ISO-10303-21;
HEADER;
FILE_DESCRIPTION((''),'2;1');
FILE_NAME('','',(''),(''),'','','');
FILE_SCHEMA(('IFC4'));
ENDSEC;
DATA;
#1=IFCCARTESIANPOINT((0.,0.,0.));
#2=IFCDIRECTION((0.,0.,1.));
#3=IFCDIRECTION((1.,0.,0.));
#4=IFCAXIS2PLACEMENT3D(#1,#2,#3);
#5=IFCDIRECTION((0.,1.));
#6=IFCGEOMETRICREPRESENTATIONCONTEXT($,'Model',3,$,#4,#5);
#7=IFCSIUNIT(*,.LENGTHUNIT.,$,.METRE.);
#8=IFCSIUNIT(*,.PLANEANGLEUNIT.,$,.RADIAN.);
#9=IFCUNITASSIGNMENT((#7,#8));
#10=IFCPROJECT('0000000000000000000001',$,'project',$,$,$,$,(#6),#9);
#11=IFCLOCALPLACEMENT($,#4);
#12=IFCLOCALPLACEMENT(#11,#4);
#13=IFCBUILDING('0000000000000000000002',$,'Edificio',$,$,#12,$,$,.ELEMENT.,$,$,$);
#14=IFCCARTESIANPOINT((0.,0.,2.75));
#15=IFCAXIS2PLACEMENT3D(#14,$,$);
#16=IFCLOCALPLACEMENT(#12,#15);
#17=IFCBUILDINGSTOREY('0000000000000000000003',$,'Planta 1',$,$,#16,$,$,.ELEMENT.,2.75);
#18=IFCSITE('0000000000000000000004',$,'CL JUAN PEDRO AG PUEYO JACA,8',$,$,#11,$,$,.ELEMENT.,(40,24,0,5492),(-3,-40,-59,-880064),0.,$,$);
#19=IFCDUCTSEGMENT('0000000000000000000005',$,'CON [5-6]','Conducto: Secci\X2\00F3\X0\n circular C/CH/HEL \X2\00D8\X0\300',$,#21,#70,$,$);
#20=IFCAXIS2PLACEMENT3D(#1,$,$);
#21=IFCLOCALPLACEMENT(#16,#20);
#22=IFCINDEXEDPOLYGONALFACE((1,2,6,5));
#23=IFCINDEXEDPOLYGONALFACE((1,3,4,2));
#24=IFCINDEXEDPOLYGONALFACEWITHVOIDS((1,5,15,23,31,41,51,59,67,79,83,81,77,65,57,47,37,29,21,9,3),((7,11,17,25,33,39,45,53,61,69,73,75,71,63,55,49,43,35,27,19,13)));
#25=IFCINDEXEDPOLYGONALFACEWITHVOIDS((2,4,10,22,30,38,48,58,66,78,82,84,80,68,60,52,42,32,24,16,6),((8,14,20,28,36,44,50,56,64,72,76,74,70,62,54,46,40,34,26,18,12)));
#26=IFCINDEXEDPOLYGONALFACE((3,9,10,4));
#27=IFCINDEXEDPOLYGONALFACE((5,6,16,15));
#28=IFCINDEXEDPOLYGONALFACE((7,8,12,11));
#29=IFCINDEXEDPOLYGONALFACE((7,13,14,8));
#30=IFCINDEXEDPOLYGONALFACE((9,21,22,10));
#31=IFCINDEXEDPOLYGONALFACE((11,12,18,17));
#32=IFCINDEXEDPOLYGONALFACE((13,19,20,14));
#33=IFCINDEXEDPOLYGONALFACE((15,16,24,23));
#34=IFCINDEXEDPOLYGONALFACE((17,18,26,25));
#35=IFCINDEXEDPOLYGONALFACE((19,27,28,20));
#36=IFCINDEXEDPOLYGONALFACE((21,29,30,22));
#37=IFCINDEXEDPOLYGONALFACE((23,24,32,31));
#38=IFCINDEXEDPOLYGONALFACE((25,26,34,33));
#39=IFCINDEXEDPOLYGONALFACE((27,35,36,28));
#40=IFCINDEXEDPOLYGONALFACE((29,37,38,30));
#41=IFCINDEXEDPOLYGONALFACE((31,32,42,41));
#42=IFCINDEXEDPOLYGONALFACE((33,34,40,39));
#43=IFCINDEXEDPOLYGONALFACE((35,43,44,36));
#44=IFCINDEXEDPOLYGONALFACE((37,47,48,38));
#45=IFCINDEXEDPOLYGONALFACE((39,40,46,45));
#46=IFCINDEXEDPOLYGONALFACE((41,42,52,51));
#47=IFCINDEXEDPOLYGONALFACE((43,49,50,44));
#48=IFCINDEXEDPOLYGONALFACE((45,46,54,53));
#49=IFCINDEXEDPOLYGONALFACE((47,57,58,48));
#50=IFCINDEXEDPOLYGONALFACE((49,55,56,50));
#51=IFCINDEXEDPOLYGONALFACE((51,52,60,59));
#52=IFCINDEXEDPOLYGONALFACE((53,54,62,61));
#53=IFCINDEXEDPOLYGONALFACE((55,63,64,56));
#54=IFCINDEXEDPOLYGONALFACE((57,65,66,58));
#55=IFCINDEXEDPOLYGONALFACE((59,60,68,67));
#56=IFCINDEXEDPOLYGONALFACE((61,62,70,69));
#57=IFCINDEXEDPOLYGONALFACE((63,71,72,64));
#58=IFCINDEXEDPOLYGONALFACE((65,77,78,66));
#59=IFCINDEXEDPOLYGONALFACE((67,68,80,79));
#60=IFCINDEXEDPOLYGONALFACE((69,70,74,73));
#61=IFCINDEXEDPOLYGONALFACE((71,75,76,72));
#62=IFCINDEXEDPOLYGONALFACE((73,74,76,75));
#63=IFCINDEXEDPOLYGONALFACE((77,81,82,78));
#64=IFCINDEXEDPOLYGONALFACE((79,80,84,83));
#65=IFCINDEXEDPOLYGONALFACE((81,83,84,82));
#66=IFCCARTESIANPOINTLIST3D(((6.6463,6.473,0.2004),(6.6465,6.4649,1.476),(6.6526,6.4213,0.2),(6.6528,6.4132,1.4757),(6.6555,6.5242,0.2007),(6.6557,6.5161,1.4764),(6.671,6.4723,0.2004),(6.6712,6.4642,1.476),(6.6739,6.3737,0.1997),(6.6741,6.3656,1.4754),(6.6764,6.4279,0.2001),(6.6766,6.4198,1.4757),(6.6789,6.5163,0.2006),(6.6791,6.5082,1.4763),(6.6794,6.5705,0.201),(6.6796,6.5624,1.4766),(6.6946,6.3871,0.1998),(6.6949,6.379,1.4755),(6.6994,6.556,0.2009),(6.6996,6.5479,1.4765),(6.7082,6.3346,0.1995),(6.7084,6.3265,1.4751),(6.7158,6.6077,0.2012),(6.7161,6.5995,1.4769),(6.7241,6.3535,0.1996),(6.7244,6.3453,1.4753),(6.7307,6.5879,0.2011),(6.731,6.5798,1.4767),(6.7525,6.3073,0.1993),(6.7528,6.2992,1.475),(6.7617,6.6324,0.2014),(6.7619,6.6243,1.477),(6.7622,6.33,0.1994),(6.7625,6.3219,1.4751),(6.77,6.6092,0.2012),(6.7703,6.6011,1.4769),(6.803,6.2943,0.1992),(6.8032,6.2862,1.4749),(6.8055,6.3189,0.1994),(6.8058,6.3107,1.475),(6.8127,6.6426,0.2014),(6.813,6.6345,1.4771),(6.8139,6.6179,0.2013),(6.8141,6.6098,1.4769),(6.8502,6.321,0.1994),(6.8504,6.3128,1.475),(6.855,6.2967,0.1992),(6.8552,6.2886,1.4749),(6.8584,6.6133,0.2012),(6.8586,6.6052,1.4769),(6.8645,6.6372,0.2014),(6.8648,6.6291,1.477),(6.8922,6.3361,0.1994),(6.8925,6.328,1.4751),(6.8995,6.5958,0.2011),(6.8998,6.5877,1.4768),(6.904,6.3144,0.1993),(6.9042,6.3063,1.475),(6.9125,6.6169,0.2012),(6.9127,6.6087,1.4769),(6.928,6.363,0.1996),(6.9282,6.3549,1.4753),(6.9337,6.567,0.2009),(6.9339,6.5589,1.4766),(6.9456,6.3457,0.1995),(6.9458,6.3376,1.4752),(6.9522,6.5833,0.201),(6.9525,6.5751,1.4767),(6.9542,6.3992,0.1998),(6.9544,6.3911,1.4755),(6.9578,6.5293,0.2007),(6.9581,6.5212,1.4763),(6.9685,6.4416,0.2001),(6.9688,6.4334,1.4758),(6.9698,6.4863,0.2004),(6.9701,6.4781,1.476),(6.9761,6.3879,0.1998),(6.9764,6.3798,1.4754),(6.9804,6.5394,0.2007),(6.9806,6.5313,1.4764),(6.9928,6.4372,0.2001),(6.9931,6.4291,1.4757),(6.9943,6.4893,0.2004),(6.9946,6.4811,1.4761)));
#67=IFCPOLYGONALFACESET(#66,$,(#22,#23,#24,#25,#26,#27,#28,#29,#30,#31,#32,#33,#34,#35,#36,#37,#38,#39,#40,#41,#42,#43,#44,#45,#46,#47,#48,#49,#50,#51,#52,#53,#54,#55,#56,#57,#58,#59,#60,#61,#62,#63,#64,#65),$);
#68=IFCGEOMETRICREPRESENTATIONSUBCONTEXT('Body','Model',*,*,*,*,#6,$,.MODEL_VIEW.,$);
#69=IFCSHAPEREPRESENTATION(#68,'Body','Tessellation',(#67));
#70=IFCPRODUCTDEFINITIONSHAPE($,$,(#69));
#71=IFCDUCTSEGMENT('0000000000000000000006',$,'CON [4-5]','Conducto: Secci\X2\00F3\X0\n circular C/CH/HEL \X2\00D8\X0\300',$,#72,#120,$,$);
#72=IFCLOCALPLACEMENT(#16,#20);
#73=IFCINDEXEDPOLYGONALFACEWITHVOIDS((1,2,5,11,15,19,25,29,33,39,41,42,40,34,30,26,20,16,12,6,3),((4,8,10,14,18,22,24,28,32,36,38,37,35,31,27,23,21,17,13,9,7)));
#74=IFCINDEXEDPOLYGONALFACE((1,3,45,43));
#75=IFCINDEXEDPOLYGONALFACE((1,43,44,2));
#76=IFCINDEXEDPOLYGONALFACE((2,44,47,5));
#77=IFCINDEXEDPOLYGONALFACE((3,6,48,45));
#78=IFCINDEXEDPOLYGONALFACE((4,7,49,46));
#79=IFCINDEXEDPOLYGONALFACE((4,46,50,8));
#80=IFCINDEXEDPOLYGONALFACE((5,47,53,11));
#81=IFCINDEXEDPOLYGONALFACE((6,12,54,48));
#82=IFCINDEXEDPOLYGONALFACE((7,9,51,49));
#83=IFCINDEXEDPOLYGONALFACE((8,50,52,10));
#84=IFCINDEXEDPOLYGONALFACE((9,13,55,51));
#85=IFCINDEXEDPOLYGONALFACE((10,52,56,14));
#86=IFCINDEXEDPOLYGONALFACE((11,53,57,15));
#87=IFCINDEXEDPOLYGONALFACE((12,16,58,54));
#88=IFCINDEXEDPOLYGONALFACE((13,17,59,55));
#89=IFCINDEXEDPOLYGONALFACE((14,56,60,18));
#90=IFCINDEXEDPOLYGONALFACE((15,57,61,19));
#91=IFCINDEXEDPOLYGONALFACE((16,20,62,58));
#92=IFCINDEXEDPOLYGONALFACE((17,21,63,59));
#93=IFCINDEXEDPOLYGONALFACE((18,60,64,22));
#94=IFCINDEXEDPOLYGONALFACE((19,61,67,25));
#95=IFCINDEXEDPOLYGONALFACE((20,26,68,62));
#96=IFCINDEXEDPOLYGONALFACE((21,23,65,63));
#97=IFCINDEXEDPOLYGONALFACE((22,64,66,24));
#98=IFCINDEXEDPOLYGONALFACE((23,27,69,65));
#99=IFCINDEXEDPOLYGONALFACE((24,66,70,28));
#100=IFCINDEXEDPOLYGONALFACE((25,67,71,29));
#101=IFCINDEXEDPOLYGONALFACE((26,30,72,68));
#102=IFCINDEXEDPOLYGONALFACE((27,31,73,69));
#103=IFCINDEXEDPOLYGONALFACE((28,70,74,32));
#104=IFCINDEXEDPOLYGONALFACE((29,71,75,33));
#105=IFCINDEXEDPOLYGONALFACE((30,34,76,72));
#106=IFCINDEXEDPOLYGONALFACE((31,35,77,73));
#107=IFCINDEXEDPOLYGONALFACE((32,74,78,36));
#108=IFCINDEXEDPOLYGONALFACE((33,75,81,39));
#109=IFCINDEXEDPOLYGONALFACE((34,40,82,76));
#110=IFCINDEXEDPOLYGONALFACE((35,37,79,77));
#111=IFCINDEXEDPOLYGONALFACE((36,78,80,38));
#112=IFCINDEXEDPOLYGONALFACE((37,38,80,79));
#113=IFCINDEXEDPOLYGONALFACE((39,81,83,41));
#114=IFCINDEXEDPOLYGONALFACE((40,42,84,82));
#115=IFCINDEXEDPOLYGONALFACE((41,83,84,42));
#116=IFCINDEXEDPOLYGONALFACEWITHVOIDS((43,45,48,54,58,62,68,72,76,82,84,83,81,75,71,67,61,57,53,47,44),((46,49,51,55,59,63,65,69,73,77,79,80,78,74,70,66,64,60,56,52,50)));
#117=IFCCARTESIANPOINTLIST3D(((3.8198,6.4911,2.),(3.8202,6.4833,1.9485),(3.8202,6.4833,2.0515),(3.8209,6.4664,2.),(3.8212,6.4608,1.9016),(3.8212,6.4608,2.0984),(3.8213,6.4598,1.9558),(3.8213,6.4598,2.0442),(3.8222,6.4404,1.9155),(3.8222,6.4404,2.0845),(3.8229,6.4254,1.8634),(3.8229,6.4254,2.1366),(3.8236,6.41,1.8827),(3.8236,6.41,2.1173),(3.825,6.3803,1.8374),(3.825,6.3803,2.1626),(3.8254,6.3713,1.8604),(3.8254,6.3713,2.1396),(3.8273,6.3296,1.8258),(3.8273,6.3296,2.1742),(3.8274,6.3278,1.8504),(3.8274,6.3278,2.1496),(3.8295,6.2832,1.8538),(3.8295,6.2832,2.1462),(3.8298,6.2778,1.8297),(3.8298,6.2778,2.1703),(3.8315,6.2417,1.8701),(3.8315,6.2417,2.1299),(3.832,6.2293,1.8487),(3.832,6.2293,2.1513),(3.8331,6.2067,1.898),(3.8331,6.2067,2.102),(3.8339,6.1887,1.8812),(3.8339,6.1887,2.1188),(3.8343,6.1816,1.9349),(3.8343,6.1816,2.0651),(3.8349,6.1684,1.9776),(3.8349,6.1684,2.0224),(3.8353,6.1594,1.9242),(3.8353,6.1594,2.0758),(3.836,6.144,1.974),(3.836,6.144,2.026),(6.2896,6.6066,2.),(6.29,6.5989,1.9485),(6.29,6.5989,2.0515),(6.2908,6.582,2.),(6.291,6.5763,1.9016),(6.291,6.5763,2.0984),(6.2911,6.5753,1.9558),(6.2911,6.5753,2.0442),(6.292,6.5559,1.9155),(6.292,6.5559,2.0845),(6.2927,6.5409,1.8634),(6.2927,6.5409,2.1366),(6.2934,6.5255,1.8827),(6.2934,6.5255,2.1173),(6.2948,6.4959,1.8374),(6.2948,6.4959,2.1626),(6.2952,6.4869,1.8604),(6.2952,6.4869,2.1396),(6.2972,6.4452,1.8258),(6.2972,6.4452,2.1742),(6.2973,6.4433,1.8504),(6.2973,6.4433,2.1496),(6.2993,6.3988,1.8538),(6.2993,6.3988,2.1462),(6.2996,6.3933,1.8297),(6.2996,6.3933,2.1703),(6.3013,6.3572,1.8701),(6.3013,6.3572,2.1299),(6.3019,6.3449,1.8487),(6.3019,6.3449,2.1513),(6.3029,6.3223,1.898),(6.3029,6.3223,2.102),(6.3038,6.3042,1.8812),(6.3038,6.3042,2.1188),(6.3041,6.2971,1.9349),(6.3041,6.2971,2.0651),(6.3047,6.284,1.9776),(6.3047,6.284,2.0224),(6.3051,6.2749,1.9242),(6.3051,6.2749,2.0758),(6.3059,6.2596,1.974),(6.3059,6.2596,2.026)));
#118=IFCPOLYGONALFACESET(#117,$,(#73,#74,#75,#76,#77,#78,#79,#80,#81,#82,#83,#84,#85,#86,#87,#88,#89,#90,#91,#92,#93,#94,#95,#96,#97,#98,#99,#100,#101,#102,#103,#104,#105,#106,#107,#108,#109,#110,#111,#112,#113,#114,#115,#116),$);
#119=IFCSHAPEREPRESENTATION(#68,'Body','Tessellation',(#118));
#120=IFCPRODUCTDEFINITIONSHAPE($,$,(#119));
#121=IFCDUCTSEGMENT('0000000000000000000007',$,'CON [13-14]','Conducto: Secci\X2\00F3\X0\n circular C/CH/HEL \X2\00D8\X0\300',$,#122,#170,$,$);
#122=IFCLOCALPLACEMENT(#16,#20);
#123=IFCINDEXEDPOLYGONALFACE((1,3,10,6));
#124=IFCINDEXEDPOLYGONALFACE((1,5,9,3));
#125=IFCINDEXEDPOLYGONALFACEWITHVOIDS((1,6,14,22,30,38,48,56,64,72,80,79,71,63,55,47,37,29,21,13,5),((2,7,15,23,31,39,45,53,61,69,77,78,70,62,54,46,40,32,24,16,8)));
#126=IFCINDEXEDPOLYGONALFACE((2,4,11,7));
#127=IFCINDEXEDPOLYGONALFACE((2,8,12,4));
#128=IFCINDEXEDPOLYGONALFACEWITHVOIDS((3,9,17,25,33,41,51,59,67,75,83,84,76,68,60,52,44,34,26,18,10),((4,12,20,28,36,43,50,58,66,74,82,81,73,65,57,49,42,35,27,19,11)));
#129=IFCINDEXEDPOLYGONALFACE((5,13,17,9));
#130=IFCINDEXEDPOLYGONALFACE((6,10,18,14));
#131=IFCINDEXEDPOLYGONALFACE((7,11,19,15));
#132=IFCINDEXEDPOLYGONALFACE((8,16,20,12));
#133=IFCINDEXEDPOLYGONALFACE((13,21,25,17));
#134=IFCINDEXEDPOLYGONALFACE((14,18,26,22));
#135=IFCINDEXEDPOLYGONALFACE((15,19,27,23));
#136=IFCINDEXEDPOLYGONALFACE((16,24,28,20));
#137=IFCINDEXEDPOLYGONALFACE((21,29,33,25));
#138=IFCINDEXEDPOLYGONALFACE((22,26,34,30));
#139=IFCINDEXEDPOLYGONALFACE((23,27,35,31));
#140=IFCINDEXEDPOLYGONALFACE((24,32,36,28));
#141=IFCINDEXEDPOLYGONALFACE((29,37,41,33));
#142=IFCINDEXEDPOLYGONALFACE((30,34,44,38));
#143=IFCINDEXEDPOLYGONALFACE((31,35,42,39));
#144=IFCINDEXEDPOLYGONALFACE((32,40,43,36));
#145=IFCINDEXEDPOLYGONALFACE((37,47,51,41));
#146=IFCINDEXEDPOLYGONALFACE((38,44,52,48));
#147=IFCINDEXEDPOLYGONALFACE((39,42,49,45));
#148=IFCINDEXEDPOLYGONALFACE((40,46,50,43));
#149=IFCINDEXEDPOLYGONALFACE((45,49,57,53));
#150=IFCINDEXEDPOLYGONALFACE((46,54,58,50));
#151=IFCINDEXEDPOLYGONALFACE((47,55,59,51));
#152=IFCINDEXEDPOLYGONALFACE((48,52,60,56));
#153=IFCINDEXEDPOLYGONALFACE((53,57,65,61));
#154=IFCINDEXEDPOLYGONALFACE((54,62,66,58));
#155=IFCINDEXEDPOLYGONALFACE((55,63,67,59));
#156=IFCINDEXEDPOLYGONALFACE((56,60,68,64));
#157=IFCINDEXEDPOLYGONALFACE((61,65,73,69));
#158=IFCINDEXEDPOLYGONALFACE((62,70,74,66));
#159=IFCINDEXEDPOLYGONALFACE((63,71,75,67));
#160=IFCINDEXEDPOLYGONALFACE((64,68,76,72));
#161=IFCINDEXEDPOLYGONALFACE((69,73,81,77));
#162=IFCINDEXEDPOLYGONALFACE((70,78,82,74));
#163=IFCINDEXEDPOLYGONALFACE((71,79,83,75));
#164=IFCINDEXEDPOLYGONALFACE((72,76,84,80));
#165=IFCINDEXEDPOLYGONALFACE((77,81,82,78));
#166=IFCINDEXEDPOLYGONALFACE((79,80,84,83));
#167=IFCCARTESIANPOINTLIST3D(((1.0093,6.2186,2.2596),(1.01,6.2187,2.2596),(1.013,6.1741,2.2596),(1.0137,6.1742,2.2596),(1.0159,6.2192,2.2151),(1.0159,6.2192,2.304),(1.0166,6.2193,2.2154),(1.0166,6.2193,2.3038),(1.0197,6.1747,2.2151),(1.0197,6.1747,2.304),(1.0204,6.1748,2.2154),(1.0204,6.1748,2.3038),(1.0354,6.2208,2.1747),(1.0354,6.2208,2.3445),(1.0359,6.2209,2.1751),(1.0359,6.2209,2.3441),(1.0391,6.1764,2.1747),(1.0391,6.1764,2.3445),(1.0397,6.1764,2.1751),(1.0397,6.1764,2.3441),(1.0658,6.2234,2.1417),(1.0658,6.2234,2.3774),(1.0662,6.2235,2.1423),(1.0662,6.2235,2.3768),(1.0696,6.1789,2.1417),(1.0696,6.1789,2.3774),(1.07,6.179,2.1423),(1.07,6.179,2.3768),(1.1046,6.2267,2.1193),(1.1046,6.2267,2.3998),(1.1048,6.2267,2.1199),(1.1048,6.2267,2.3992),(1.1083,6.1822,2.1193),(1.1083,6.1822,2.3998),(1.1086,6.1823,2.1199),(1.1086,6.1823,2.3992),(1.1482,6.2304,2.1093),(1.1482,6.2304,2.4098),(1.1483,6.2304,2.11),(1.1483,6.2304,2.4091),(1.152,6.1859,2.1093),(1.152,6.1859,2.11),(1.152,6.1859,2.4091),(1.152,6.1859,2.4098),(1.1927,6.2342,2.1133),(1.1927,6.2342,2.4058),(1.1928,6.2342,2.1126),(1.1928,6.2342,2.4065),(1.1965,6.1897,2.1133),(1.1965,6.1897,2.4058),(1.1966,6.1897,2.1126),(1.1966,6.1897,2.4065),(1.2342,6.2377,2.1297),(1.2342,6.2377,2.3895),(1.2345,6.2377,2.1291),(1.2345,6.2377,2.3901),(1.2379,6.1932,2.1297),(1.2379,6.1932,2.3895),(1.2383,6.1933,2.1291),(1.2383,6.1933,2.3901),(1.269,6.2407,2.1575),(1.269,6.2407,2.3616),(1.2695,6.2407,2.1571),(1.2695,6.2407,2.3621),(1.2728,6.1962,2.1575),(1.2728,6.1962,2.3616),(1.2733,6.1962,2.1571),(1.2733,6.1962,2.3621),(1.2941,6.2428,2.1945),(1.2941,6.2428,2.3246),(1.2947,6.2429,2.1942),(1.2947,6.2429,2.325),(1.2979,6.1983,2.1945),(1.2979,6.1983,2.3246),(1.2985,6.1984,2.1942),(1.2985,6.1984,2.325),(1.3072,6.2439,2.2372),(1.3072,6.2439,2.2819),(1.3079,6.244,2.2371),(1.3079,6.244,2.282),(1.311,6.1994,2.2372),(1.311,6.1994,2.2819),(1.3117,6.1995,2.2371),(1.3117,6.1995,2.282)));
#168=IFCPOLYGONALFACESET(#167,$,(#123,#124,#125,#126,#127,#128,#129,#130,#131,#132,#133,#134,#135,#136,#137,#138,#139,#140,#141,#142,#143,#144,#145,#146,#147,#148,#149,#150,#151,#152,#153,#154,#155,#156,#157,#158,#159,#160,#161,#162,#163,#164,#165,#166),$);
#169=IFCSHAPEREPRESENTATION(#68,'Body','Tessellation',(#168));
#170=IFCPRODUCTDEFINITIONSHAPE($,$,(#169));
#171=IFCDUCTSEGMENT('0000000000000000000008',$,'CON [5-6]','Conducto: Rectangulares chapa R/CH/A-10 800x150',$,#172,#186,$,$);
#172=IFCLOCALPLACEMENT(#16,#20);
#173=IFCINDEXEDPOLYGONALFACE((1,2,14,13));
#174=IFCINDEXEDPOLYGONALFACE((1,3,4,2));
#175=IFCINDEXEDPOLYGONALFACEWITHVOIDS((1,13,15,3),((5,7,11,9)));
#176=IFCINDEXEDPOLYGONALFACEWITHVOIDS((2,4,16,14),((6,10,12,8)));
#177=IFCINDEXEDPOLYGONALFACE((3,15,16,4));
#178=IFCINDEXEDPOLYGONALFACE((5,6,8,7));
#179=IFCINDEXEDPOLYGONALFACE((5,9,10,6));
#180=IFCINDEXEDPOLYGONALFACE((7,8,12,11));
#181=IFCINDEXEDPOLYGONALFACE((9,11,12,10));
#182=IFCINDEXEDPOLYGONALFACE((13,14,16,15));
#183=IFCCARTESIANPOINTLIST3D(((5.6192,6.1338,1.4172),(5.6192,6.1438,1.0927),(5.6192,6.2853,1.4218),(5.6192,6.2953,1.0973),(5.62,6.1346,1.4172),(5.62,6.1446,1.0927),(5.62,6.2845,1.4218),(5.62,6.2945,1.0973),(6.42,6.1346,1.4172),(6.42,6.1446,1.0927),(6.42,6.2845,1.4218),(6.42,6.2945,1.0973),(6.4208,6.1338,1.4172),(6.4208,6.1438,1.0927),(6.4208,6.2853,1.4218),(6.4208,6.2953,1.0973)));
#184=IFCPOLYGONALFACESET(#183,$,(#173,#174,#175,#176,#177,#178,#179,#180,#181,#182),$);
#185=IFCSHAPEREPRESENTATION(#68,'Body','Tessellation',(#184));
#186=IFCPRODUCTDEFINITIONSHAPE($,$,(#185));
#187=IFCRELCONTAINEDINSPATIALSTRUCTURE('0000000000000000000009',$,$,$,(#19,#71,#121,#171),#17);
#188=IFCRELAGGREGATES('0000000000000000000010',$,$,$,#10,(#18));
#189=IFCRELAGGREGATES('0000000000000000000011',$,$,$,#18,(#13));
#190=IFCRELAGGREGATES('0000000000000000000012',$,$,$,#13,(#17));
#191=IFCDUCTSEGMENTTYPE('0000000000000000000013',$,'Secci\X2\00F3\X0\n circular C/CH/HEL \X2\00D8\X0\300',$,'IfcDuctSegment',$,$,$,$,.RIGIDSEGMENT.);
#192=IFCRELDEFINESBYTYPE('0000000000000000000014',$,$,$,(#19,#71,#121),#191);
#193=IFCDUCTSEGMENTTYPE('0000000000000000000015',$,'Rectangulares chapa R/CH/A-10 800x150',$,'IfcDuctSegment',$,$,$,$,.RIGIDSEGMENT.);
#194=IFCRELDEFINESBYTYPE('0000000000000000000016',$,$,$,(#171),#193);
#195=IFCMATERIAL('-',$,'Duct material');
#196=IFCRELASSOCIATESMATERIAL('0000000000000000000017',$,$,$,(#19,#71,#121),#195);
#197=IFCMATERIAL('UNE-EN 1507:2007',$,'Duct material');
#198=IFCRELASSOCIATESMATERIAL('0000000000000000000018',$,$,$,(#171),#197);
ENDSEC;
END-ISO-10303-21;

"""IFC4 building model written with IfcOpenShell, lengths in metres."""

from ifc_helpers import new_model, si_unit, direction, frame, origin_with_axes, origin_2d_with_axis, place, context, subcontext, project, spatial, hollow_rectangle, hollow_circle, extrude, material, type_object, element, save


model = new_model("IFC4")

# Units and contexts
model_context = context("Model", 3, world=origin_with_axes(), true_north=direction((0.0, 1.0)))
body_context = subcontext(model_context, "Body", "Model", "MODEL_VIEW")
ifc_project = project(units=[si_unit("LENGTHUNIT", "METRE"), si_unit("PLANEANGLEUNIT", "RADIAN")], contexts=[model_context])

# Site, building, storey
site_placement = place(None, origin_with_axes())
site = spatial("IfcSite", under=ifc_project, at=site_placement, Name="CL JUAN PEDRO AG PUEYO JACA,8", CompositionType="ELEMENT", RefLatitude=(40, 24, 0, 5492), RefLongitude=(-3, -40, -59, -880064), RefElevation=0.0)
building_placement = place(site_placement, origin_with_axes())
building = spatial("IfcBuilding", under=site, at=building_placement, Name="Edificio", CompositionType="ELEMENT")
storey_placement = place(building_placement, frame((0.0, 0.0, 2.75)))
storey = spatial("IfcBuildingStorey", under=building, at=storey_placement, Name="Planta 1", CompositionType="ELEMENT", Elevation=2.75)

# Shared definitions
ifc_material_1 = material(Name="-", Category="Duct material")

# Duct segments
duct_segment_type_1 = type_object("IfcDuctSegmentType", Name="Sección circular C/CH/HEL Ø300", ApplicableOccurrence="IfcDuctSegment", PredefinedType="RIGIDSEGMENT")
duct_segment_1_placement = place(storey_placement, frame((0.0, 0.0, -2.75), z_axis=(0.0, 0.0, 1.0), x_axis=(1.0, 0.0, 0.0)))
element("IfcDuctSegment", 1, at=duct_segment_1_placement, inside=storey, type_object=duct_segment_type_1, material=ifc_material_1, Name="CON [5-6]", Description="Conducto: Sección circular C/CH/HEL Ø300", context=body_context, shape_type="SweptSolid", body=[
    extrude(hollow_circle(Radius=0.1747, WallThickness=0.0247, at=origin_2d_with_axis()), frame((6.8212, 6.46, 4.226), z_axis=(-0.000203, 0.006364, -0.99998), x_axis=(-0.04673, 0.998887, 0.006367)), (0.0, 0.0, 1.0), 1.2757),
])
duct_segment_2_placement = place(storey_placement, frame((0.0, 0.0, -2.75), z_axis=(0.0, 0.0, 1.0), x_axis=(1.0, 0.0, 0.0)))
element("IfcDuctSegment", 2, at=duct_segment_2_placement, inside=storey, type_object=duct_segment_type_1, material=ifc_material_1, Name="CON [4-5]", Description="Conducto: Sección circular C/CH/HEL Ø300", context=body_context, shape_type="SweptSolid", body=[
    extrude(hollow_circle(Radius=0.1747, WallThickness=0.0247, at=origin_2d_with_axis()), frame((3.828, 6.3166, 4.75), z_axis=(0.998907, 0.046731, 0.0), x_axis=(-0.046731, 0.998907, 0.0)), (0.0, 0.0, 1.0), 2.4725),
])
duct_segment_3_placement = place(storey_placement, frame((0.0, 0.0, -2.75), z_axis=(0.0, 0.0, 1.0), x_axis=(1.0, 0.0, 0.0)))
element("IfcDuctSegment", 3, at=duct_segment_3_placement, inside=storey, type_object=duct_segment_type_1, material=ifc_material_1, Name="CON [13-14]", Description="Conducto: Sección circular C/CH/HEL Ø300", context=body_context, shape_type="SweptSolid", body=[
    extrude(hollow_circle(Radius=0.1507, WallThickness=0.0007, at=origin_2d_with_axis()), frame((1.1632, 6.1869, 5.0096), z_axis=(-0.084581, 0.996417, 0.0), x_axis=(-0.996417, -0.084581, 0.0)), (0.0, 0.0, 1.0), 0.0446),
])
ifc_material_2 = material(Name="UNE-EN 1507:2007", Category="Duct material")
duct_segment_type_2 = type_object("IfcDuctSegmentType", Name="Rectangulares chapa R/CH/A-10 800x150", ApplicableOccurrence="IfcDuctSegment", PredefinedType="RIGIDSEGMENT")
duct_segment_4_placement = place(storey_placement, frame((0.0, 0.0, -2.75), z_axis=(0.0, 0.0, 1.0), x_axis=(1.0, 0.0, 0.0)))
element("IfcDuctSegment", 4, at=duct_segment_4_placement, inside=storey, type_object=duct_segment_type_2, material=ifc_material_2, Name="CON [5-6]", Description="Conducto: Rectangulares chapa R/CH/A-10 800x150", context=body_context, shape_type="SweptSolid", body=[
    extrude(hollow_rectangle(XDim=0.8016, YDim=0.1516, WallThickness=0.0008, at=origin_2d_with_axis()), frame((6.02, 6.2195, 3.845), z_axis=(0.0, -0.030865, 0.999524), x_axis=(1.0, 0.0, 0.0)), (0.0, 0.0, 1.0), 0.3247),
])

save(model, "model.ifc")
